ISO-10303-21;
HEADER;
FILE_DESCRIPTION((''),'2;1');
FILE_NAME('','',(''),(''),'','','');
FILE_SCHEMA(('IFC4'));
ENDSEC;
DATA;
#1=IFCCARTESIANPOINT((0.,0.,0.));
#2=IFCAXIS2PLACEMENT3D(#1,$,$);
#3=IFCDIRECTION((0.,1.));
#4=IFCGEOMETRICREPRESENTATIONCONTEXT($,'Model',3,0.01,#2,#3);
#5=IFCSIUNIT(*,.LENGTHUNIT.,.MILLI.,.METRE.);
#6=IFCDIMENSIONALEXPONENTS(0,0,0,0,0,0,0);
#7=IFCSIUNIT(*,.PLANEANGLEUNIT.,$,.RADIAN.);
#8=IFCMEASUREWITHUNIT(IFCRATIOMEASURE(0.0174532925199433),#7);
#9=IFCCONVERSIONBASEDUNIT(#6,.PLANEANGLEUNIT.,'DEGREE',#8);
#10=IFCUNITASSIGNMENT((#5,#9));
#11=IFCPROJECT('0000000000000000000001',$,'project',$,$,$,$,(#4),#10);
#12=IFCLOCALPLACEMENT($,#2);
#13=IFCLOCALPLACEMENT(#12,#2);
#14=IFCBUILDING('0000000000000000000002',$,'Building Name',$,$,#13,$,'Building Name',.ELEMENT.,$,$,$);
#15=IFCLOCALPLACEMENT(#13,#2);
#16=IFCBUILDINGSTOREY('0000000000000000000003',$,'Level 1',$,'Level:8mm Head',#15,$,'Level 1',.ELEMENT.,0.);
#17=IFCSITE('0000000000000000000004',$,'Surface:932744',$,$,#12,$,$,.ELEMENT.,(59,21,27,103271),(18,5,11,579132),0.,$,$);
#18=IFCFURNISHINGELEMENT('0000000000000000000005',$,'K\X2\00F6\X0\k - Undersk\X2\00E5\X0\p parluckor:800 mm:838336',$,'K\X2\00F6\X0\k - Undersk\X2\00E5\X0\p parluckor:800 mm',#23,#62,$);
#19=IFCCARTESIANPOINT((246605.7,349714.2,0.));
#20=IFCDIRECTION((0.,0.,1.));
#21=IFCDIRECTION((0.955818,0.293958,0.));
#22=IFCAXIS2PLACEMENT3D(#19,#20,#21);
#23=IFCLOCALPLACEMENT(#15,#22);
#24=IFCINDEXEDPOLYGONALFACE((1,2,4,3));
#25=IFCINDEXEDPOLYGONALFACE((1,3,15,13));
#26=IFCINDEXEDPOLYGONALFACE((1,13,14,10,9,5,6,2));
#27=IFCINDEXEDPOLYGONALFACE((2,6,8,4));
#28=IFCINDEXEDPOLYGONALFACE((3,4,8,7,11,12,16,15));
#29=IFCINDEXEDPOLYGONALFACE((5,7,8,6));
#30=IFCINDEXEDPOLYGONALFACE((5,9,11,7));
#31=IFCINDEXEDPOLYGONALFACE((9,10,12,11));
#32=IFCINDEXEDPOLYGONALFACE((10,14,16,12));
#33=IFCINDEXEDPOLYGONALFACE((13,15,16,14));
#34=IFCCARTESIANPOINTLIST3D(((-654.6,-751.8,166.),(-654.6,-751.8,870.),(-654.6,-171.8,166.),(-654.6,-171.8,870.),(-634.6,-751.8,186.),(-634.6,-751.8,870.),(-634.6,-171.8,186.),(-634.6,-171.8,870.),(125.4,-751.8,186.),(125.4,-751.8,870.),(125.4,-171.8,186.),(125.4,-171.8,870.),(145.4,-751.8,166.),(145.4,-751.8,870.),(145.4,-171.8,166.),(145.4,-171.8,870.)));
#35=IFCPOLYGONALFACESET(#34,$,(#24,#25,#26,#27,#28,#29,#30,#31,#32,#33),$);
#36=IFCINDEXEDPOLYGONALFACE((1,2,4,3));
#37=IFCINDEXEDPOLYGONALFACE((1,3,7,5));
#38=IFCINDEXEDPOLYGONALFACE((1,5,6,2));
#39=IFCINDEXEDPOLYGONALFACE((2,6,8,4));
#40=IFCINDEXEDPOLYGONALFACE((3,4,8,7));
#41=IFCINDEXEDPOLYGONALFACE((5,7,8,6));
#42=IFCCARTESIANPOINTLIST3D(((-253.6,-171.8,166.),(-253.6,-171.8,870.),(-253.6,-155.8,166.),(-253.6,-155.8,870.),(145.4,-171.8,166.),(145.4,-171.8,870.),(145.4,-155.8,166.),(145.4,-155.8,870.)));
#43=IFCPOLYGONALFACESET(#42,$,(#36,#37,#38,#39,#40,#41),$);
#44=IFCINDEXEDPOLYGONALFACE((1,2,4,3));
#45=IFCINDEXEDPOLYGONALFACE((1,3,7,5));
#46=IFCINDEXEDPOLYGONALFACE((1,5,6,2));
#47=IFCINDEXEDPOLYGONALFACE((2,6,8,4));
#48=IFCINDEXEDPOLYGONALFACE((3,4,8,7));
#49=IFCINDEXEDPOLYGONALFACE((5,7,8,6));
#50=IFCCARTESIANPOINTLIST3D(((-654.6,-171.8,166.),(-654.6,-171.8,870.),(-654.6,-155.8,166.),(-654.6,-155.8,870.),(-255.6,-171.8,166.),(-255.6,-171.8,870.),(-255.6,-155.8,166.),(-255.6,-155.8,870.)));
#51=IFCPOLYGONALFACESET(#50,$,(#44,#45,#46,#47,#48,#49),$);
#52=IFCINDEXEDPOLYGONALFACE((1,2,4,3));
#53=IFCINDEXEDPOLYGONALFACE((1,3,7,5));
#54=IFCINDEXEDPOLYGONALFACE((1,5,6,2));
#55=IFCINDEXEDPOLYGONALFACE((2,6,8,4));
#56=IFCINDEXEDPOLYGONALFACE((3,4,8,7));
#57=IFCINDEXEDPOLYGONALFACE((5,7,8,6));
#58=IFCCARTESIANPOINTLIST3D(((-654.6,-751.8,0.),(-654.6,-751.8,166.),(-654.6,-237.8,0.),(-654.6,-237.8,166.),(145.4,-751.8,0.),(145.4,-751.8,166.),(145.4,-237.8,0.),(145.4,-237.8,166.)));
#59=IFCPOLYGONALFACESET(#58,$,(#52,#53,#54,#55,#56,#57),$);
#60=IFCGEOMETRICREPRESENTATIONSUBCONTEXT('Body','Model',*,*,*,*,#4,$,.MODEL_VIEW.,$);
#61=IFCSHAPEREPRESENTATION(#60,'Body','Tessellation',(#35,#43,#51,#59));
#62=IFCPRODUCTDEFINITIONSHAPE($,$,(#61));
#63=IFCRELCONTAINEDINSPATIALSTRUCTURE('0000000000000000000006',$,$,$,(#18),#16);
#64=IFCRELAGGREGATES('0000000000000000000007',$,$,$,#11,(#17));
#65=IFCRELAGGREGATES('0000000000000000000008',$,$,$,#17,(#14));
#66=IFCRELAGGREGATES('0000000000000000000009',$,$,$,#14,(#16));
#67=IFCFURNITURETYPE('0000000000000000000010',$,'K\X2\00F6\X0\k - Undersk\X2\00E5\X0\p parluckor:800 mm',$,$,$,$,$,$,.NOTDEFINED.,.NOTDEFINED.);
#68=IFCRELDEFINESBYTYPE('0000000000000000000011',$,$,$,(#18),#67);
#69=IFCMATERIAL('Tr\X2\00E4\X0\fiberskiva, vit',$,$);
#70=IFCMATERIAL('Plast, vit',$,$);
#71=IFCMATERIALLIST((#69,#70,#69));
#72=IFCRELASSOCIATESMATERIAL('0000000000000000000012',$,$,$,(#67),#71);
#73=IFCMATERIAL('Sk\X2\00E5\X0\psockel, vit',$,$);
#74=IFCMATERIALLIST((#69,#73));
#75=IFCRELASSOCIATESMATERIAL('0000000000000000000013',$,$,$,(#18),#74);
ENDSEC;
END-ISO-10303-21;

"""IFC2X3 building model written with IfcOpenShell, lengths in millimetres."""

from ifc_helpers import new_model, entity, si_unit, converted_unit, direction, frame, frame_2d, origin, origin_2d_with_axis, place, context, subcontext, project, spatial, polyline, rectangle, outline, extrude, source, transform, mapped, material, material_list, type_object, type_shapes, element, save


model = new_model("IFC2X3")

# Units and contexts
model_context = context("Model", 3, precision=0.01, world=origin(), true_north=direction((0.0, 1.0)))
body_context = subcontext(model_context, "Body", "Model", "MODEL_VIEW")
ifc_project = project(units=[si_unit("LENGTHUNIT", "METRE", prefix="MILLI"), converted_unit("PLANEANGLEUNIT", "DEGREE", entity("IfcRatioMeasure", 0.0174532925199433), si_unit("PLANEANGLEUNIT", "RADIAN"), dimensions=[0, 0, 0, 0, 0, 0, 0])], contexts=[model_context])

# Site, building, storey
site_placement = place(None, origin())
site = spatial("IfcSite", under=ifc_project, at=site_placement, Name="Surface:932744", CompositionType="ELEMENT", RefLatitude=(59, 21, 27, 103271), RefLongitude=(18, 5, 11, 579132), RefElevation=0.0)
building_placement = place(site_placement, origin())
building = spatial("IfcBuilding", under=site, at=building_placement, Name="Building Name", LongName="Building Name", CompositionType="ELEMENT")
storey_placement = place(building_placement, origin())
storey = spatial("IfcBuildingStorey", under=building, at=storey_placement, Name="Level 1", ObjectType="Level:8mm Head", LongName="Level 1", CompositionType="ELEMENT", Elevation=0.0)

# Furnishing element
ifc_material_1 = material(Name="Träfiberskiva, vit")
ifc_material_2 = material(Name="Skåpsockel, vit")
ifc_material_3 = material(Name="Plast, vit")
ifc_material_list_1 = material_list([ifc_material_1, ifc_material_2])
ifc_material_list_2 = material_list([ifc_material_1, ifc_material_3, ifc_material_1])
furniture_type_1 = type_object("IfcFurnitureType", Name="Kök - Underskåp parluckor:800 mm", material=ifc_material_list_2)
shared_shape_1 = source(origin(), body_context, "Body", "SweptSolid", [
    extrude(outline(polyline([(-400.0, -347.0), (-380.0, -347.0), (-380.0, 337.0), (380.0, 337.0), (380.0, -347.0), (400.0, -347.0), (400.0, 357.0), (-400.0, 357.0), (-400.0, -347.0)])), frame((-254.6, -751.8, 523.0), z_axis=(0.0, 1.0, 0.0), x_axis=(1.0, 0.0, 0.0)), (0.0, 0.0, 1.0), 580.0),
    extrude(rectangle(XDim=399.0, YDim=16.0, at=frame_2d((0.0, 0.0), x_axis=(1.0, 0.0))), frame((-54.1, -163.8, 166.0), z_axis=(0.0, 0.0, 1.0), x_axis=(-1.0, 0.0, 0.0)), (0.0, 0.0, 1.0), 704.0),
    extrude(rectangle(XDim=399.0, YDim=16.0, at=frame_2d((0.0, 0.0), x_axis=(1.0, 0.0))), frame((-455.1, -163.8, 166.0), z_axis=(0.0, 0.0, 1.0), x_axis=(-1.0, 0.0, 0.0)), (0.0, 0.0, 1.0), 704.0),
    extrude(rectangle(XDim=514.0, YDim=800.0, at=origin_2d_with_axis()), frame((-254.6, -494.8, 0.0), z_axis=(0.0, 0.0, 1.0), x_axis=(0.0, 1.0, 0.0)), (0.0, 0.0, 1.0), 166.0),
])
type_shapes(furniture_type_1, [shared_shape_1])
furnishing_1_placement = place(storey_placement, frame((246605.7, 349714.2, 0.0), z_axis=(0.0, 0.0, 1.0), x_axis=(0.955818, 0.293958, 0.0)))
element("IfcFurnishingElement", 1, at=furnishing_1_placement, inside=storey, type_object=furniture_type_1, material=ifc_material_list_1, Name="Kök - Underskåp parluckor:800 mm:838336", ObjectType="Kök - Underskåp parluckor:800 mm", context=body_context, shape_type="MappedRepresentation", body=[
    mapped(shared_shape_1, transform((0.0, 0.0, 0.0), scale=1.0)),
])

save(model, "model.ifc")
